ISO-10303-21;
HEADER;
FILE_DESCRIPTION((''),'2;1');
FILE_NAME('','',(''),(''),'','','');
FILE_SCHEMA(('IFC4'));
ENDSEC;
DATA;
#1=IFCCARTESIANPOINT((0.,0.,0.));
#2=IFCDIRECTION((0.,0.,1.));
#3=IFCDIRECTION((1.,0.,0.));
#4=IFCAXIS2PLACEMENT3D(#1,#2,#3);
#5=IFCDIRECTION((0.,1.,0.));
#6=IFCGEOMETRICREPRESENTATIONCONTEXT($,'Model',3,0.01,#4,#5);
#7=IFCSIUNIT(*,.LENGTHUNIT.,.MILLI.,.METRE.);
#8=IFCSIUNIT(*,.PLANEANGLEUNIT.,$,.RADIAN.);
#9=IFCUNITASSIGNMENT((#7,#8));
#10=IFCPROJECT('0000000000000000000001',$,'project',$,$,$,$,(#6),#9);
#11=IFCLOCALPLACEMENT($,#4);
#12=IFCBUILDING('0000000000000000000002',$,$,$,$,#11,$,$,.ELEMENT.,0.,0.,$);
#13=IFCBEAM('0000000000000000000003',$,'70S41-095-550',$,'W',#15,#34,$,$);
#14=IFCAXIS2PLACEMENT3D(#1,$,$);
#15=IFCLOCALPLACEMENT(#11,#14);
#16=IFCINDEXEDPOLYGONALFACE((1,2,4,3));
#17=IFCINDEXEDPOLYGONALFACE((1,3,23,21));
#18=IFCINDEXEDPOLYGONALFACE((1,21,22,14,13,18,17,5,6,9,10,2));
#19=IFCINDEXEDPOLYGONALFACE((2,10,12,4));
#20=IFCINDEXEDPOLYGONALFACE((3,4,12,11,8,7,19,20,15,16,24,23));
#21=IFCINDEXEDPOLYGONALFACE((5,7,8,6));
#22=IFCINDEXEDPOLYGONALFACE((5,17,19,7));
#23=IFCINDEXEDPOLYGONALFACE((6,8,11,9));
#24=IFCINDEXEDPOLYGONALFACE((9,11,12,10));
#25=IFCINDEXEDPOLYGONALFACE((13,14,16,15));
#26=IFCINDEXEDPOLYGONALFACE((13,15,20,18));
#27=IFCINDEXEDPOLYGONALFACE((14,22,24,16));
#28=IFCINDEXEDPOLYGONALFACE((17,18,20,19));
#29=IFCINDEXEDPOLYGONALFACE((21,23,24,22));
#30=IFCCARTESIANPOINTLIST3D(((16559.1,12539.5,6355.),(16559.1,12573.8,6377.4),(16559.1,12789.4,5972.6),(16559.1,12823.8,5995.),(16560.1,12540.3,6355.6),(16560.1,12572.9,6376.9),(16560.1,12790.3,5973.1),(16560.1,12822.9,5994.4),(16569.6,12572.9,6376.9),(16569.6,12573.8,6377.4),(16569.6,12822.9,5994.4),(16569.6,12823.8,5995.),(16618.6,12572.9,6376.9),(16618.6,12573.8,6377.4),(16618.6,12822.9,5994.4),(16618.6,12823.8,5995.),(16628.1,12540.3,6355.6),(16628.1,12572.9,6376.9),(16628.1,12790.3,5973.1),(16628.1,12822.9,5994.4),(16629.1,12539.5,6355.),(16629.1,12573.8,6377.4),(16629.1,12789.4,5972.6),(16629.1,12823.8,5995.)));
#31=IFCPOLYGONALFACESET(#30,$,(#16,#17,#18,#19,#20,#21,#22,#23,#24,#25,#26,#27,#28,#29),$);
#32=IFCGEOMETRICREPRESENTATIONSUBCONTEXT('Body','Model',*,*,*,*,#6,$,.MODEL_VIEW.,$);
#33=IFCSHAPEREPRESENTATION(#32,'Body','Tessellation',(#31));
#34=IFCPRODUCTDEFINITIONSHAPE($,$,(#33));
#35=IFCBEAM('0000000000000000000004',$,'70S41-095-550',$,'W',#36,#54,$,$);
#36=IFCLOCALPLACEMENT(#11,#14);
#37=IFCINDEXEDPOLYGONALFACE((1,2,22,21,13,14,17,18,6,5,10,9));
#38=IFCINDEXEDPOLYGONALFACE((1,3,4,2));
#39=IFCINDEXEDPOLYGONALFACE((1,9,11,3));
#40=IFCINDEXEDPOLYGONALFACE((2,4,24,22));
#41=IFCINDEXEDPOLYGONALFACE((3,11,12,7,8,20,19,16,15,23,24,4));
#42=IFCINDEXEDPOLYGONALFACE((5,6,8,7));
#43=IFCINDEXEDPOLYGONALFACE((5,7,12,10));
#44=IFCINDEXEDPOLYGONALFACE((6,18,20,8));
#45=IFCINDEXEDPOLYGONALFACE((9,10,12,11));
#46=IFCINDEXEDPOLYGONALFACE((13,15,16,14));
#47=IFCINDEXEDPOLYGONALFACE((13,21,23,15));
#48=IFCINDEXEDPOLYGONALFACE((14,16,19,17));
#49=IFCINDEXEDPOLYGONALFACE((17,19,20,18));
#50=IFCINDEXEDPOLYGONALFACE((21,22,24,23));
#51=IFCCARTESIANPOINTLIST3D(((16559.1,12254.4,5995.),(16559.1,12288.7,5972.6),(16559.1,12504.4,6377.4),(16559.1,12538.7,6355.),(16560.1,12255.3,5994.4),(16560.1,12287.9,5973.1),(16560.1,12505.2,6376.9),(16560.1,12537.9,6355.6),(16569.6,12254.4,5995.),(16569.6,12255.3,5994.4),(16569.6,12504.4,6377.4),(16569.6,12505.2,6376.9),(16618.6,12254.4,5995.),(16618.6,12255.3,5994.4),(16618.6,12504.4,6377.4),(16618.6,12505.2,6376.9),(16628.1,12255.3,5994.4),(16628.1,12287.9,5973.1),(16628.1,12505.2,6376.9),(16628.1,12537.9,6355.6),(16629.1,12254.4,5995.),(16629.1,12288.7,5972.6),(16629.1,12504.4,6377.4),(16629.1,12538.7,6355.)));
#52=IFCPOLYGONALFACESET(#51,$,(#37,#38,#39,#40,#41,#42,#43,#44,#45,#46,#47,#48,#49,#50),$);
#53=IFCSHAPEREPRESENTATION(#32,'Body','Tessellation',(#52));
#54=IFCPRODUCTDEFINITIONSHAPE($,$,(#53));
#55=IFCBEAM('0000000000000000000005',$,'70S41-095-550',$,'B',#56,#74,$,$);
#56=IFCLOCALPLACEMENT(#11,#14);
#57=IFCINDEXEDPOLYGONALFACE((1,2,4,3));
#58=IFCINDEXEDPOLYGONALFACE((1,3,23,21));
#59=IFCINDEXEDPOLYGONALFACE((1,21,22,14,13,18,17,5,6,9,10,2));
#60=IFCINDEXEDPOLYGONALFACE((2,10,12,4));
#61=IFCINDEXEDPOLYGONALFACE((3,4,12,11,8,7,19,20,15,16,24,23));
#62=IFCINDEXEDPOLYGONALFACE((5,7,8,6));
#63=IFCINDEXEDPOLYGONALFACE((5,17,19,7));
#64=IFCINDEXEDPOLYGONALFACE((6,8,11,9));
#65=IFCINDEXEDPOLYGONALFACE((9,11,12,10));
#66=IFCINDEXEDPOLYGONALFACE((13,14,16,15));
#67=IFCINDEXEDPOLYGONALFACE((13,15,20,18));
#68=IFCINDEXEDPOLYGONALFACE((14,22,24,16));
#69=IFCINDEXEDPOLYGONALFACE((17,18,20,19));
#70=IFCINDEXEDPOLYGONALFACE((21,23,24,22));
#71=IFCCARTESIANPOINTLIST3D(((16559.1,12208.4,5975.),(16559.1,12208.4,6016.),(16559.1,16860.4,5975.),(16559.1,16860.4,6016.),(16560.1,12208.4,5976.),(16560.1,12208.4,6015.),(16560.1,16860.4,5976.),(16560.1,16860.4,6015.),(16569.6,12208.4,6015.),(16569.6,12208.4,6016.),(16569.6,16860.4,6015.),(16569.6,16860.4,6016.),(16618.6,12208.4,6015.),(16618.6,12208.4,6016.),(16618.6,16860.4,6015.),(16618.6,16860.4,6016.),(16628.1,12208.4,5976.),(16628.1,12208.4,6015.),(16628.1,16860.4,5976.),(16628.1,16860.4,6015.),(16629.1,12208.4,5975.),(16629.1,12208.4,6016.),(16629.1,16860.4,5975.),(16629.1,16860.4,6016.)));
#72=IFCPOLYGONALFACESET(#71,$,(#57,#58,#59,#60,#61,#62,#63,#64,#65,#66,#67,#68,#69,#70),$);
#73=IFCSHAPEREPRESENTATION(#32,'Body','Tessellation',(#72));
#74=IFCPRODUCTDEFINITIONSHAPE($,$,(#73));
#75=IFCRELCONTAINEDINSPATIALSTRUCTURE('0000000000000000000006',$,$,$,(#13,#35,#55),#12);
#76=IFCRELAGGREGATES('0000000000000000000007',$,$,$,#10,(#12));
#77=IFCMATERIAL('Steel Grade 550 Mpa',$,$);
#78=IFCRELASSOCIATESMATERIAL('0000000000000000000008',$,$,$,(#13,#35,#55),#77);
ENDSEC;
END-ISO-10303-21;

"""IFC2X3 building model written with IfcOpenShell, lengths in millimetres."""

from ifc_helpers import new_model, si_unit, direction, frame, origin, origin_with_axes, origin_2d_with_axis, place, context, subcontext, project, spatial, c_section, extrude, source, transform, mapped, material, element, save


model = new_model("IFC2X3")

# Units and contexts
model_context = context("Model", 3, precision=0.01, world=origin_with_axes(), true_north=direction((0.0, 1.0, 0.0)))
body_context = subcontext(model_context, "Body", "Model", "MODEL_VIEW")
ifc_project = project(units=[si_unit("LENGTHUNIT", "METRE", prefix="MILLI"), si_unit("PLANEANGLEUNIT", "RADIAN")], contexts=[model_context])

# Building
building_placement = place(None, origin_with_axes())
building = spatial("IfcBuilding", under=ifc_project, at=building_placement, CompositionType="ELEMENT", ElevationOfRefHeight=0.0, ElevationOfTerrain=0.0)

# Shared definitions
ifc_material = material(Name="Steel Grade 550 Mpa")

# Beams
shared_shape_1 = source(origin(), body_context, "Body", "SweptSolid", [
    extrude(c_section(Depth=70.0, Width=41.0, WallThickness=1.0, Girth=10.5, at=origin_2d_with_axis()), origin_with_axes(), (0.0, 0.0, 1.0), 456.9),
])
beam_1_placement = place(None, frame((16594.1, 12556.6, 6366.2), z_axis=(0.0, 0.547116, -0.837057), x_axis=(0.0, 0.837057, 0.547116)))
element("IfcBeam", 1, at=beam_1_placement, inside=building, material=ifc_material, Name="70S41-095-550", ObjectType="W", context=body_context, shape_type="MappedRepresentation", body=[
    mapped(shared_shape_1, transform((0.0, 0.0, 0.0), scale=1.0)),
])
shared_shape_2 = source(origin(), body_context, "Body", "SweptSolid", [
    extrude(c_section(Depth=70.0, Width=41.0, WallThickness=1.0, Girth=10.5, at=origin_2d_with_axis()), origin_with_axes(), (0.0, 0.0, 1.0), 456.9),
])
beam_2_placement = place(None, frame((16594.1, 12271.6, 5983.8), z_axis=(0.0, 0.547116, 0.837057), x_axis=(0.0, -0.837057, 0.547116)))
element("IfcBeam", 2, at=beam_2_placement, inside=building, material=ifc_material, Name="70S41-095-550", ObjectType="W", context=body_context, shape_type="MappedRepresentation", body=[
    mapped(shared_shape_2, transform((0.0, 0.0, 0.0), scale=1.0)),
])
shared_shape_3 = source(origin(), body_context, "Body", "SweptSolid", [
    extrude(c_section(Depth=70.0, Width=41.0, WallThickness=1.0, Girth=10.5, at=origin_2d_with_axis()), origin_with_axes(), (0.0, 0.0, 1.0), 4652.0),
])
beam_3_placement = place(None, frame((16594.1, 12208.4, 5995.5), z_axis=(0.0, 1.0, 0.0), x_axis=(0.0, 0.0, 1.0)))
element("IfcBeam", 3, at=beam_3_placement, inside=building, material=ifc_material, Name="70S41-095-550", ObjectType="B", context=body_context, shape_type="MappedRepresentation", body=[
    mapped(shared_shape_3, transform((0.0, 0.0, 0.0), scale=1.0)),
])

save(model, "model.ifc")
